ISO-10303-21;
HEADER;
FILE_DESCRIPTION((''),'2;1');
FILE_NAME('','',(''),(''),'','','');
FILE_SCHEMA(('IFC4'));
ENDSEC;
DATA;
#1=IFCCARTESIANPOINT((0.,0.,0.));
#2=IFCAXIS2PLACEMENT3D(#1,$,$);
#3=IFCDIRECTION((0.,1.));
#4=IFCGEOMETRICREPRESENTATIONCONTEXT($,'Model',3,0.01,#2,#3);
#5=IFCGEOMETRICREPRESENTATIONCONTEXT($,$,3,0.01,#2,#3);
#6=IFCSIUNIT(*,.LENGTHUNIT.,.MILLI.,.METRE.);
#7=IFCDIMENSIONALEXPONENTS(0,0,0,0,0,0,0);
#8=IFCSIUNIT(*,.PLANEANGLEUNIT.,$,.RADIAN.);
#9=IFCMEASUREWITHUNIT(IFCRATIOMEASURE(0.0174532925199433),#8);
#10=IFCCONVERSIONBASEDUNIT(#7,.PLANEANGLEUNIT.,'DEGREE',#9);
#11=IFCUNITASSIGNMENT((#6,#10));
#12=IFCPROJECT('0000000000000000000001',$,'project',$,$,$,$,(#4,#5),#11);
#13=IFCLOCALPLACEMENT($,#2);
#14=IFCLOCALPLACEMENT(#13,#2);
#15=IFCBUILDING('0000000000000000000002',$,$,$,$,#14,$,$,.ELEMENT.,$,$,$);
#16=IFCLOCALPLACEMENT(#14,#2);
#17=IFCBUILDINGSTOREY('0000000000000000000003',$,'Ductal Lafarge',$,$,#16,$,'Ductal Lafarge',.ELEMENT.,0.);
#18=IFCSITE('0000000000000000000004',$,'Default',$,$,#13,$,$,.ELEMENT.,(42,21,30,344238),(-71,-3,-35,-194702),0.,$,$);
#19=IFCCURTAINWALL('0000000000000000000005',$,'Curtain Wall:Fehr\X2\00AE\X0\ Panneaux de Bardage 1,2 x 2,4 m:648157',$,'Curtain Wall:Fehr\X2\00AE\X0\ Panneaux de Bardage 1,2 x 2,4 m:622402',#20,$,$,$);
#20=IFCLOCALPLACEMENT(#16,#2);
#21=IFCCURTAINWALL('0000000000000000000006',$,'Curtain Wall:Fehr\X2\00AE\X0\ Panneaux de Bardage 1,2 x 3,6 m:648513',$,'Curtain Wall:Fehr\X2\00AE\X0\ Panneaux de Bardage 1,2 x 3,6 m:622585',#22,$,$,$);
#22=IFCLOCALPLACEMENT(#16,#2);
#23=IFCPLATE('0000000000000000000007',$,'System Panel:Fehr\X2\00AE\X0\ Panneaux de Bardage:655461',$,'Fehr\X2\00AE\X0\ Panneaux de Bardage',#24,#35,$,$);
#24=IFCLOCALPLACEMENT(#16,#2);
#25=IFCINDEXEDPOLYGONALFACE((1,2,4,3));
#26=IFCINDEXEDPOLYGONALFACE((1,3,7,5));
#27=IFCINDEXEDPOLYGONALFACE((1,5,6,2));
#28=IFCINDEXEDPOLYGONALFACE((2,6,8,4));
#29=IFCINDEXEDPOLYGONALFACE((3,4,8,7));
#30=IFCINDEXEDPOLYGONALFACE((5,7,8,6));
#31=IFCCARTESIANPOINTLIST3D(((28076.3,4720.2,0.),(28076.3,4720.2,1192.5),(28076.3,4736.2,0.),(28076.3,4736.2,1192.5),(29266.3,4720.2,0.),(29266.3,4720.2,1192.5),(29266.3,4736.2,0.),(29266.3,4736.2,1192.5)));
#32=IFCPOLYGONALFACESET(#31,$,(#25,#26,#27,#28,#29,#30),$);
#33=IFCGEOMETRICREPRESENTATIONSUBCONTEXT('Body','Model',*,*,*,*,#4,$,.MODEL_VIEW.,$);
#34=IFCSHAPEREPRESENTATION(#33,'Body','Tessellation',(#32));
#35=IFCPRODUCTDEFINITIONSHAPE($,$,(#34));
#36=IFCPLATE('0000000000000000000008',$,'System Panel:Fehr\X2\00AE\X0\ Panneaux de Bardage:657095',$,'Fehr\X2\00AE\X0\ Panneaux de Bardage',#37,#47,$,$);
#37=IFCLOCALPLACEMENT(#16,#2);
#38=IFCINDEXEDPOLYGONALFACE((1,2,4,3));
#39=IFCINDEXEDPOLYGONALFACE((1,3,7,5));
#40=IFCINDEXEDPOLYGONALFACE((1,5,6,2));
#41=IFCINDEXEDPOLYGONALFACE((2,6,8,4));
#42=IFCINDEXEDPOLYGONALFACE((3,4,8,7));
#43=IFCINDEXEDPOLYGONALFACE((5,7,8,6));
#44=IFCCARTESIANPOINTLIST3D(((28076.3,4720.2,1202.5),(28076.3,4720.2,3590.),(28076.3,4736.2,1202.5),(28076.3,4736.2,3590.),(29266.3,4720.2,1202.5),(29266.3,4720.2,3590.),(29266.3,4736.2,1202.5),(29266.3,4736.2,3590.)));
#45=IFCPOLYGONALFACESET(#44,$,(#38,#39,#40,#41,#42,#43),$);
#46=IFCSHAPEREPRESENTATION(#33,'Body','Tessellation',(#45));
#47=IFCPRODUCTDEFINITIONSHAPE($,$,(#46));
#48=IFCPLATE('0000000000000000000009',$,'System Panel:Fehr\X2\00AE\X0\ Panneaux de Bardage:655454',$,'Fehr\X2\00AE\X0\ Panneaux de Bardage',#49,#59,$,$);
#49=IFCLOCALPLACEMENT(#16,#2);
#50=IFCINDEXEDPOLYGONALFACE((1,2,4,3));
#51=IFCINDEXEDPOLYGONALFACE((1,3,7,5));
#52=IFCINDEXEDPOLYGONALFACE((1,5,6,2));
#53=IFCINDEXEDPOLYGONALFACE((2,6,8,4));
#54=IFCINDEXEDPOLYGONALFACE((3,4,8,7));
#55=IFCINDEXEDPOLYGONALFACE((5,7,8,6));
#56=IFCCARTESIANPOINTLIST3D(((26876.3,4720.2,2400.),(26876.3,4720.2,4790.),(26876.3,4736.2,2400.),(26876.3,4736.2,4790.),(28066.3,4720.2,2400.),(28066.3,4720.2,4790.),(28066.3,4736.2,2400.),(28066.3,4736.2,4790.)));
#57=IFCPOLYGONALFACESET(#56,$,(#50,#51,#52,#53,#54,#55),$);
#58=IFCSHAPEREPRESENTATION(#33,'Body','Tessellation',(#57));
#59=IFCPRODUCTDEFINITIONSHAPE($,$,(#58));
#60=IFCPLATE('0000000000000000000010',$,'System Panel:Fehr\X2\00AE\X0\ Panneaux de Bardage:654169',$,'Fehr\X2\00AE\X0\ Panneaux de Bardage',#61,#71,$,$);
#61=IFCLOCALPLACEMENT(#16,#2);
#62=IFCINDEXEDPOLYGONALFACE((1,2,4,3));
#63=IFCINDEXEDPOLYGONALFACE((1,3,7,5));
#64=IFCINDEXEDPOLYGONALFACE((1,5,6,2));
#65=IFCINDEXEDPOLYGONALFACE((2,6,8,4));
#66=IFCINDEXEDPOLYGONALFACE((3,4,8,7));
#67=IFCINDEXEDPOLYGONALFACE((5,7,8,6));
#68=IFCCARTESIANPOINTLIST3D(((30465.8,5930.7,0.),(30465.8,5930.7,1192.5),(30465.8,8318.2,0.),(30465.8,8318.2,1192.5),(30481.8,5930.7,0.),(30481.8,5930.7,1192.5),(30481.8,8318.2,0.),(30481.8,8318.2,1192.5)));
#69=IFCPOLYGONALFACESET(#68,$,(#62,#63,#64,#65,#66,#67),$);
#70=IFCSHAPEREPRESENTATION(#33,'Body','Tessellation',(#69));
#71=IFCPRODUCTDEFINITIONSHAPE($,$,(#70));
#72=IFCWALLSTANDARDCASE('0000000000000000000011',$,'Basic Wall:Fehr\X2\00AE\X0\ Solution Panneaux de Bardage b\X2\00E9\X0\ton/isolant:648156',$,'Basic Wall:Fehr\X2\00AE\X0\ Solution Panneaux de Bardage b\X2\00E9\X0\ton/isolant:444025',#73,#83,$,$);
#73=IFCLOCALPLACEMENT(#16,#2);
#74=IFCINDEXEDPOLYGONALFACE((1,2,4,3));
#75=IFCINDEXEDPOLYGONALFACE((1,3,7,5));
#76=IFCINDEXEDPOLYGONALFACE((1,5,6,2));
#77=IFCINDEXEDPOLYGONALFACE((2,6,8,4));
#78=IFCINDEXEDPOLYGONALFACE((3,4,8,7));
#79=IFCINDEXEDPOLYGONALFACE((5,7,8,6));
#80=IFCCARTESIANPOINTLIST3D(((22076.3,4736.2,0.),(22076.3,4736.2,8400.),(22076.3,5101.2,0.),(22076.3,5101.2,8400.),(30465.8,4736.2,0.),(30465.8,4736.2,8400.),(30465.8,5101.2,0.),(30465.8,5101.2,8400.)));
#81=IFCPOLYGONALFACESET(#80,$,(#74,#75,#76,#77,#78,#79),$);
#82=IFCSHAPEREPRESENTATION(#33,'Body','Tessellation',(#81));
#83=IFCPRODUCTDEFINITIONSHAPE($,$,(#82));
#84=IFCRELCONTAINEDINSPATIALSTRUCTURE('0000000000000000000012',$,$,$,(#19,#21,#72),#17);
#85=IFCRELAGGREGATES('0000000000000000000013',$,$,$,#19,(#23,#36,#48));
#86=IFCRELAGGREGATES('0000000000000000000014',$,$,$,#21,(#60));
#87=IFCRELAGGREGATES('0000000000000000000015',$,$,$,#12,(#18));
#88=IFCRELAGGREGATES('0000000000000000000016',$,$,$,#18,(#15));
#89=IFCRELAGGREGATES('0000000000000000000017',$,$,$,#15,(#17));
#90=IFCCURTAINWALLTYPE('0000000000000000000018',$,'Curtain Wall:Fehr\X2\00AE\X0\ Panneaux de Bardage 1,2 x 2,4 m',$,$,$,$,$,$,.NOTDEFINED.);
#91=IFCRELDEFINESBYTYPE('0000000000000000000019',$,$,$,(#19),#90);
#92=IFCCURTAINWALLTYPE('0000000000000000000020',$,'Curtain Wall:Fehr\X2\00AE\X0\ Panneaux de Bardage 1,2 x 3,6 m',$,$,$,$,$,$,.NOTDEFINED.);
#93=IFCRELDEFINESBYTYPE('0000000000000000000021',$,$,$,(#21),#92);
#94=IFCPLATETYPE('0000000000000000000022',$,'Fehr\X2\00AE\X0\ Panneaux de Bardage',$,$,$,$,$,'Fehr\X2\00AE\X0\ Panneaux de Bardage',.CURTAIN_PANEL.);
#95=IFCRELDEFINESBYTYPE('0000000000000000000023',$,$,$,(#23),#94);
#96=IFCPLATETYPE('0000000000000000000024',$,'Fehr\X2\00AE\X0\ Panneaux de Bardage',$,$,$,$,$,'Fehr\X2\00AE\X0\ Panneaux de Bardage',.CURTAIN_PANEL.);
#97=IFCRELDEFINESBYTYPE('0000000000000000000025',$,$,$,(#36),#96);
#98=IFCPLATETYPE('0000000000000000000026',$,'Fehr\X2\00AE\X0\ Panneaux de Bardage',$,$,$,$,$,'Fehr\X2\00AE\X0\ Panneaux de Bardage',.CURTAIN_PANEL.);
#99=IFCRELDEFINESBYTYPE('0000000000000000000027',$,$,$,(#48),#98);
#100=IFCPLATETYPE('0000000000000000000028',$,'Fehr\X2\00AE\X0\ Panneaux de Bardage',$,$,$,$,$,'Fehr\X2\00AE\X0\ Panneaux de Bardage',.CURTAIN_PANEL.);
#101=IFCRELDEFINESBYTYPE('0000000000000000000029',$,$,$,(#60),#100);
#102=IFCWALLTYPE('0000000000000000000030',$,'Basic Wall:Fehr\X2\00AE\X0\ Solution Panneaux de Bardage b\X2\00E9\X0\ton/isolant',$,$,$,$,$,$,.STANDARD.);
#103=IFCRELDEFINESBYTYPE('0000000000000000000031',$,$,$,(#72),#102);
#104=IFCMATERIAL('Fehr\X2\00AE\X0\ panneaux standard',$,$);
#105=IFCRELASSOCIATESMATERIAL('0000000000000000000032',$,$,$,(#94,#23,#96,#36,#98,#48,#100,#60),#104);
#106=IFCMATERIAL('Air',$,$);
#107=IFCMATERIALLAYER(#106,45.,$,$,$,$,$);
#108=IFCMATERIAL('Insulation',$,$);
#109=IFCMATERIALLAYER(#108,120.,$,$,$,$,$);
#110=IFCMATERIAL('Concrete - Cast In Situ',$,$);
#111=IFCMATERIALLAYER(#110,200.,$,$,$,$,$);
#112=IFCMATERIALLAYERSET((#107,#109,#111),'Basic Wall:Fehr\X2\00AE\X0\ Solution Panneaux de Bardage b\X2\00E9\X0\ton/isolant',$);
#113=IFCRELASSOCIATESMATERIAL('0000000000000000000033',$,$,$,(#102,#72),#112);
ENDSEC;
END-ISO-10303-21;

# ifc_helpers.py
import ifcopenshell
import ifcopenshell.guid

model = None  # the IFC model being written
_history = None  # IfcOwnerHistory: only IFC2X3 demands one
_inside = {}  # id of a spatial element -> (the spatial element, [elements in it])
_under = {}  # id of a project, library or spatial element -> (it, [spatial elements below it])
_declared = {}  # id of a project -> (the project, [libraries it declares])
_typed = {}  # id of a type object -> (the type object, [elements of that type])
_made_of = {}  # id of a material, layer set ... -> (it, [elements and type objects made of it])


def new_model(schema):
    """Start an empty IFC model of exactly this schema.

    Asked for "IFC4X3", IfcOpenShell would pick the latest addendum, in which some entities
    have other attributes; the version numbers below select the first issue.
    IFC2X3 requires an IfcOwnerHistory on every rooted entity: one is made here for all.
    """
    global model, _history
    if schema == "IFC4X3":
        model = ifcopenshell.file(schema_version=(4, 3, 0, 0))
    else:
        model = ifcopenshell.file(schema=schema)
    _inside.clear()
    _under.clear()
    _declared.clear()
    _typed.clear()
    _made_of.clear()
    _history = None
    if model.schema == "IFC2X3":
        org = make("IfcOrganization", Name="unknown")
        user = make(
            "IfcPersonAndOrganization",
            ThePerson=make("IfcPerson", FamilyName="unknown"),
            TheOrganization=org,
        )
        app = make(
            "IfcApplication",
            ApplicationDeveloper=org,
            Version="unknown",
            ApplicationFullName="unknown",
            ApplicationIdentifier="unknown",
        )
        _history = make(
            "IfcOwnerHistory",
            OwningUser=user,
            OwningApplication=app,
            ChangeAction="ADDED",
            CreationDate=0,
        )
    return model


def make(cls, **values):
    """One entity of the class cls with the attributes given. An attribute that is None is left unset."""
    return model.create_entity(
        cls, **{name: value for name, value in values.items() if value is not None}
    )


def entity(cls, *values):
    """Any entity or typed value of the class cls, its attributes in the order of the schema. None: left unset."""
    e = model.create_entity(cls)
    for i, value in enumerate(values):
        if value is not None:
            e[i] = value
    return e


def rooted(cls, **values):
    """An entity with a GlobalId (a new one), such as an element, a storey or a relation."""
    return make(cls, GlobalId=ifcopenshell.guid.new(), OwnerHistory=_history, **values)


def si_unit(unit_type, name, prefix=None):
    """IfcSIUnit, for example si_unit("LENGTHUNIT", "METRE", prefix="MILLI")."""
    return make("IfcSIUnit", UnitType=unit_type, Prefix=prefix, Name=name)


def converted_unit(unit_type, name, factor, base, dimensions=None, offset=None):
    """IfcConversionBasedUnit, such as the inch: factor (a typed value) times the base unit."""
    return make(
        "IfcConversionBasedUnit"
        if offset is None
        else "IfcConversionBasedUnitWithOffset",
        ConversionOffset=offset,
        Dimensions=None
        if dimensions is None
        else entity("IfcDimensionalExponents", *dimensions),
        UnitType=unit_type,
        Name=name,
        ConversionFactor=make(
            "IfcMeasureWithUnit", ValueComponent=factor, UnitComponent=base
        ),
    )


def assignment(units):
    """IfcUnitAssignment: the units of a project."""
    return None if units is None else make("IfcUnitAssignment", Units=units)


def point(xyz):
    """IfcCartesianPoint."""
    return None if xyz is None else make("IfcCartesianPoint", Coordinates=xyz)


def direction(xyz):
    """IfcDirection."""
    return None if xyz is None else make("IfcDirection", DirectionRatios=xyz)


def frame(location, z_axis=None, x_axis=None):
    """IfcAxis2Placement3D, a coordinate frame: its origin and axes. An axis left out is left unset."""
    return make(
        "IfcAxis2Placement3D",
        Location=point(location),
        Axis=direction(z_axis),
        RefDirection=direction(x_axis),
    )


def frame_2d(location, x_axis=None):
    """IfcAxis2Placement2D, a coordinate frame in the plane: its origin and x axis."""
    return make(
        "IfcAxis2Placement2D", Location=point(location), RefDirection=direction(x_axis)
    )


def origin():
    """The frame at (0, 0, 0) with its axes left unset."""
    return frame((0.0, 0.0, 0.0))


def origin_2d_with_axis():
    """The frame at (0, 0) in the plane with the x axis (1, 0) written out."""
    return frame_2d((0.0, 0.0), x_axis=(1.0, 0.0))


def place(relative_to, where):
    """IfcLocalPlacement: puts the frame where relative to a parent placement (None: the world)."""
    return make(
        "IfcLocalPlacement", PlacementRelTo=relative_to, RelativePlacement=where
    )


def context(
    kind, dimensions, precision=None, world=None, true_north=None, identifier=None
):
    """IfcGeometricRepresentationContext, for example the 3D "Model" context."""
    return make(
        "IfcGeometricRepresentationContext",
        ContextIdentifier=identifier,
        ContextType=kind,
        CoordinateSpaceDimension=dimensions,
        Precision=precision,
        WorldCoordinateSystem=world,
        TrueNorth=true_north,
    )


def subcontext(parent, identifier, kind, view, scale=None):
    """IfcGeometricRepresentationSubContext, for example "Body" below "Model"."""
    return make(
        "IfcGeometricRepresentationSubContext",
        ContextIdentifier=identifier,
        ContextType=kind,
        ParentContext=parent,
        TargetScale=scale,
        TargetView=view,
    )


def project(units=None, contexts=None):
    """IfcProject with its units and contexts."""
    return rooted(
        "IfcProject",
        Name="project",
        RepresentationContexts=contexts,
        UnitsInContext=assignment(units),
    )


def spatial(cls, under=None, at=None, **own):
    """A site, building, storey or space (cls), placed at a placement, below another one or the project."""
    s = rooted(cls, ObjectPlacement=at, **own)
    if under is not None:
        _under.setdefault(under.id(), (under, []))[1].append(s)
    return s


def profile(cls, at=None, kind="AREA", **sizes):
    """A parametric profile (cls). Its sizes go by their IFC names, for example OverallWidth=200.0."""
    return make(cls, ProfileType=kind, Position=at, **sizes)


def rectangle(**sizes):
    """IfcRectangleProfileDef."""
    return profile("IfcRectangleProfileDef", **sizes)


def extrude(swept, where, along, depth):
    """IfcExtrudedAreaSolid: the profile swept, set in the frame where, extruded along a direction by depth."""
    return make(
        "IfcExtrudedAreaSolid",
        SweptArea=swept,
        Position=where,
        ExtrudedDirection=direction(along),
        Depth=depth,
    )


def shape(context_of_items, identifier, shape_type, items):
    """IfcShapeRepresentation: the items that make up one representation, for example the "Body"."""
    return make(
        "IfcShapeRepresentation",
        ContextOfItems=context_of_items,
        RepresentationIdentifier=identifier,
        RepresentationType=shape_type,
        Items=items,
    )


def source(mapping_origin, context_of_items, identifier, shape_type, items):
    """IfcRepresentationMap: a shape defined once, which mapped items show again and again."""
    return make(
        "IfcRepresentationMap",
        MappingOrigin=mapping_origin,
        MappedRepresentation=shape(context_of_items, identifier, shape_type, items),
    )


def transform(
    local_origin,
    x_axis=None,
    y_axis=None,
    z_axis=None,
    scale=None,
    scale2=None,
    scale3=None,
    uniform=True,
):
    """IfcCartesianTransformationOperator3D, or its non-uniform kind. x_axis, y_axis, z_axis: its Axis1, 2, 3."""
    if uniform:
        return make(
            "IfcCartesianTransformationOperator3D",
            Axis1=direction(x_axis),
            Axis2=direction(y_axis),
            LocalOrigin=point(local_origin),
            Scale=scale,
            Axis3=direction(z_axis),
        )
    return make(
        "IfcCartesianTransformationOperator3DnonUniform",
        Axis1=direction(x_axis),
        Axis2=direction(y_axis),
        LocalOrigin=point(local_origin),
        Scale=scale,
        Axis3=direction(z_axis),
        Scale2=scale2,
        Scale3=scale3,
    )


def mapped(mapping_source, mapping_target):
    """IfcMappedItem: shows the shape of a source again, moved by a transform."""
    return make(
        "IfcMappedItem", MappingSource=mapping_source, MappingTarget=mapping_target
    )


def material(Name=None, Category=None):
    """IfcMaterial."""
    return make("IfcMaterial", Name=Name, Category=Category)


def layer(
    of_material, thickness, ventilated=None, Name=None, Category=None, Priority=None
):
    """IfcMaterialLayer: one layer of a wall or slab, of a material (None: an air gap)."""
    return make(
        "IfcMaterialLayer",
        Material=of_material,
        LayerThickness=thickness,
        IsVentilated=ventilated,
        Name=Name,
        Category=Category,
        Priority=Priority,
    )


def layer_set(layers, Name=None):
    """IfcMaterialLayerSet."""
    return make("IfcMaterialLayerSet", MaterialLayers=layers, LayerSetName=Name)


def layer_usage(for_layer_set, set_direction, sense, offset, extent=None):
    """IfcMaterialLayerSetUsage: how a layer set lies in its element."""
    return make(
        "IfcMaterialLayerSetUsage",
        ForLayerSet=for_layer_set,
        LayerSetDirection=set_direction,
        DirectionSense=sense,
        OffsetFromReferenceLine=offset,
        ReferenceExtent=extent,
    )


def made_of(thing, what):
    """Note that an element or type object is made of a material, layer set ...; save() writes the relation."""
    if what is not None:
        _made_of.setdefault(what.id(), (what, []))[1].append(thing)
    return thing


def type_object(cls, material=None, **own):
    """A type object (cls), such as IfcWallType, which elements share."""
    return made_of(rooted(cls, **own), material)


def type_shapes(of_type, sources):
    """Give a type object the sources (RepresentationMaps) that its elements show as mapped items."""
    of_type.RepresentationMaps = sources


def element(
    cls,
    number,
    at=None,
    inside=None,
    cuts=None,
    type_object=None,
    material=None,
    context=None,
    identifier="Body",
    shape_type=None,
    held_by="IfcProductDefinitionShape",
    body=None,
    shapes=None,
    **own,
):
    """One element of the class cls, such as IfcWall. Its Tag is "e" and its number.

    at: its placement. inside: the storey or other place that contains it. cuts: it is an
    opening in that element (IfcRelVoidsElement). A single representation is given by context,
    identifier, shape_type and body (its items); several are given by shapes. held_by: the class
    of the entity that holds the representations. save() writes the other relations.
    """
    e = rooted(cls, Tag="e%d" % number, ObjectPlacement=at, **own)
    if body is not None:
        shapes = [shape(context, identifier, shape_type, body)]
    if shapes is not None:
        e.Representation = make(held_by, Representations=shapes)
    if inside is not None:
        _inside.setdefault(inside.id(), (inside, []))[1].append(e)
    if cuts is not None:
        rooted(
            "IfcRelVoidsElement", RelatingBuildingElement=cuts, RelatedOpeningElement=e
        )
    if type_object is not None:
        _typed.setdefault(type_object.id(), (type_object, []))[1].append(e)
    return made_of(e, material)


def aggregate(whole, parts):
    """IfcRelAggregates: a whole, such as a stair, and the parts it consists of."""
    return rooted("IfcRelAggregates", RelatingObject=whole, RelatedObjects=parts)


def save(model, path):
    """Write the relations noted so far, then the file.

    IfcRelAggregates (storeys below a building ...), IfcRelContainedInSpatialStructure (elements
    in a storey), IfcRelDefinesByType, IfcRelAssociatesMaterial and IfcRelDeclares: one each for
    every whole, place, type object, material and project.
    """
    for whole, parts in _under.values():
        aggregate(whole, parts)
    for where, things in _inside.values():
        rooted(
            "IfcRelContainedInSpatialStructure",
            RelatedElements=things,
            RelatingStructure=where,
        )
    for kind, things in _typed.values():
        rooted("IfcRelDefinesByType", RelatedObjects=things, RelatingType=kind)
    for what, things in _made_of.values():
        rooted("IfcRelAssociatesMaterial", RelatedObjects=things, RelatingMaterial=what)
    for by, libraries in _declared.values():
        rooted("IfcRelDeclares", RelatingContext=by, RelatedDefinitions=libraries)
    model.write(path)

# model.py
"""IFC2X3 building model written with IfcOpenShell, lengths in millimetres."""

from ifc_helpers import new_model, entity, si_unit, converted_unit, direction, frame, frame_2d, origin, origin_2d_with_axis, place, context, subcontext, project, spatial, rectangle, extrude, source, transform, mapped, material, layer, layer_set, layer_usage, type_object, type_shapes, element, aggregate, save


model = new_model("IFC2X3")

# Units and contexts
model_context = context("Model", 3, precision=0.01, world=origin(), true_north=direction((0.0, 1.0)))
context_of_model = context(None, 3, precision=0.01, world=origin(), true_north=direction((0.0, 1.0)))
body_context = subcontext(model_context, "Body", "Model", "MODEL_VIEW")
ifc_project = project(units=[si_unit("LENGTHUNIT", "METRE", prefix="MILLI"), converted_unit("PLANEANGLEUNIT", "DEGREE", entity("IfcRatioMeasure", 0.0174532925199433), si_unit("PLANEANGLEUNIT", "RADIAN"), dimensions=[0, 0, 0, 0, 0, 0, 0])], contexts=[model_context, context_of_model])

# Site, building, storey
site_placement = place(None, origin())
site = spatial("IfcSite", under=ifc_project, at=site_placement, Name="Default", CompositionType="ELEMENT", RefLatitude=(42, 21, 30, 344238), RefLongitude=(-71, -3, -35, -194702), RefElevation=0.0)
building_placement = place(site_placement, origin())
building = spatial("IfcBuilding", under=site, at=building_placement, CompositionType="ELEMENT")
storey_placement = place(building_placement, origin())
storey = spatial("IfcBuildingStorey", under=building, at=storey_placement, Name="Ductal Lafarge", LongName="Ductal Lafarge", CompositionType="ELEMENT", Elevation=0.0)

# Curtain walls
curtain_wall_type_1 = type_object("IfcCurtainWallType", Name="Curtain Wall:Fehr® Panneaux de Bardage 1,2 x 2,4 m", PredefinedType="NOTDEFINED")
curtain_wall_1_placement = place(storey_placement, origin())
curtain_wall_1 = element("IfcCurtainWall", 1, at=curtain_wall_1_placement, inside=storey, type_object=curtain_wall_type_1, Name="Curtain Wall:Fehr® Panneaux de Bardage 1,2 x 2,4 m:648157", ObjectType="Curtain Wall:Fehr® Panneaux de Bardage 1,2 x 2,4 m:622402")
curtain_wall_type_2 = type_object("IfcCurtainWallType", Name="Curtain Wall:Fehr® Panneaux de Bardage 1,2 x 3,6 m", PredefinedType="NOTDEFINED")
curtain_wall_2_placement = place(storey_placement, origin())
curtain_wall_2 = element("IfcCurtainWall", 2, at=curtain_wall_2_placement, inside=storey, type_object=curtain_wall_type_2, Name="Curtain Wall:Fehr® Panneaux de Bardage 1,2 x 3,6 m:648513", ObjectType="Curtain Wall:Fehr® Panneaux de Bardage 1,2 x 3,6 m:622585")

# Plates
ifc_material_1 = material(Name="Fehr® panneaux standard")
plate_type_1 = type_object("IfcPlateType", Name="Fehr® Panneaux de Bardage", ElementType="Fehr® Panneaux de Bardage", PredefinedType="CURTAIN_PANEL", material=ifc_material_1)
shared_shape_1 = source(origin(), body_context, "Body", "SweptSolid", [
    extrude(rectangle(XDim=16.0, YDim=1190.0, at=origin_2d_with_axis()), frame((0.0, 0.0, 0.0), z_axis=(0.0, 0.0, 1.0), x_axis=(0.0, 1.0, 0.0)), (0.0, 0.0, 1.0), 1192.5),
])
type_shapes(plate_type_1, [shared_shape_1])
plate_1_placement = place(curtain_wall_1_placement, frame((28671.3, 4728.2, 0.0)))
plate_1 = element("IfcPlate", 3, at=plate_1_placement, type_object=plate_type_1, material=ifc_material_1, Name="System Panel:Fehr® Panneaux de Bardage:655461", ObjectType="Fehr® Panneaux de Bardage", context=body_context, shape_type="MappedRepresentation", body=[
    mapped(shared_shape_1, transform((0.0, 0.0, 0.0), scale=1.0)),
])
plate_type_2 = type_object("IfcPlateType", Name="Fehr® Panneaux de Bardage", ElementType="Fehr® Panneaux de Bardage", PredefinedType="CURTAIN_PANEL", material=ifc_material_1)
shared_shape_2 = source(origin(), body_context, "Body", "SweptSolid", [
    extrude(rectangle(XDim=2387.5, YDim=1190.0, at=frame_2d((0.4, 0.0), x_axis=(1.0, 0.0))), frame((0.0, -8.0, 1193.3), z_axis=(0.0, 1.0, 0.0), x_axis=(0.0, 0.0, 1.0)), (0.0, 0.0, 1.0), 16.0),
])
type_shapes(plate_type_2, [shared_shape_2])
plate_2_placement = place(curtain_wall_1_placement, frame((28671.3, 4728.2, 1202.5)))
plate_2 = element("IfcPlate", 4, at=plate_2_placement, type_object=plate_type_2, material=ifc_material_1, Name="System Panel:Fehr® Panneaux de Bardage:657095", ObjectType="Fehr® Panneaux de Bardage", context=body_context, shape_type="MappedRepresentation", body=[
    mapped(shared_shape_2, transform((0.0, 0.0, 0.0), scale=1.0)),
])
plate_type_3 = type_object("IfcPlateType", Name="Fehr® Panneaux de Bardage", ElementType="Fehr® Panneaux de Bardage", PredefinedType="CURTAIN_PANEL", material=ifc_material_1)
shared_shape_3 = source(origin(), body_context, "Body", "SweptSolid", [
    extrude(rectangle(XDim=2390.0, YDim=1190.0, at=origin_2d_with_axis()), frame((0.0, -8.0, 1195.0), z_axis=(0.0, 1.0, 0.0), x_axis=(0.0, 0.0, 1.0)), (0.0, 0.0, 1.0), 16.0),
])
type_shapes(plate_type_3, [shared_shape_3])
plate_3_placement = place(curtain_wall_1_placement, frame((27471.3, 4728.2, 2400.0)))
plate_3 = element("IfcPlate", 5, at=plate_3_placement, type_object=plate_type_3, material=ifc_material_1, Name="System Panel:Fehr® Panneaux de Bardage:655454", ObjectType="Fehr® Panneaux de Bardage", context=body_context, shape_type="MappedRepresentation", body=[
    mapped(shared_shape_3, transform((0.0, 0.0, 0.0), scale=1.0)),
])
aggregate(curtain_wall_1, [plate_1, plate_2, plate_3])
plate_type_4 = type_object("IfcPlateType", Name="Fehr® Panneaux de Bardage", ElementType="Fehr® Panneaux de Bardage", PredefinedType="CURTAIN_PANEL", material=ifc_material_1)
shared_shape_4 = source(origin(), body_context, "Body", "SweptSolid", [
    extrude(rectangle(XDim=1192.5, YDim=2387.5, at=frame_2d((0.0, 0.4), x_axis=(1.0, 0.0))), frame((-0.4, -8.0, 596.2), z_axis=(0.0, 1.0, 0.0), x_axis=(0.0, 0.0, 1.0)), (0.0, 0.0, 1.0), 16.0),
])
type_shapes(plate_type_4, [shared_shape_4])
plate_4_placement = place(curtain_wall_2_placement, frame((30473.8, 7124.4, 0.0), z_axis=(0.0, 0.0, 1.0), x_axis=(0.0, 1.0, 0.0)))
plate_4 = element("IfcPlate", 6, at=plate_4_placement, type_object=plate_type_4, material=ifc_material_1, Name="System Panel:Fehr® Panneaux de Bardage:654169", ObjectType="Fehr® Panneaux de Bardage", context=body_context, shape_type="MappedRepresentation", body=[
    mapped(shared_shape_4, transform((0.0, 0.0, 0.0), scale=1.0)),
])
aggregate(curtain_wall_2, [plate_4])

# Wall
ifc_material_2 = material(Name="Air")
ifc_layer_1 = layer(ifc_material_2, 45.0)
ifc_material_3 = material(Name="Insulation")
ifc_layer_2 = layer(ifc_material_3, 120.0)
ifc_material_4 = material(Name="Concrete - Cast In Situ")
ifc_layer_3 = layer(ifc_material_4, 200.0)
ifc_layer_set = layer_set([ifc_layer_1, ifc_layer_2, ifc_layer_3], Name="Basic Wall:Fehr® Solution Panneaux de Bardage béton/isolant")
ifc_layer_usage = layer_usage(ifc_layer_set, "AXIS2", "NEGATIVE", 182.5)
wall_type = type_object("IfcWallType", Name="Basic Wall:Fehr® Solution Panneaux de Bardage béton/isolant", PredefinedType="STANDARD", material=ifc_layer_set)
wall_placement = place(storey_placement, frame((30465.8, 4918.7, 0.0), z_axis=(0.0, 0.0, 1.0), x_axis=(-1.0, 0.0, 0.0)))
element("IfcWallStandardCase", 7, at=wall_placement, inside=storey, type_object=wall_type, material=ifc_layer_usage, Name="Basic Wall:Fehr® Solution Panneaux de Bardage béton/isolant:648156", ObjectType="Basic Wall:Fehr® Solution Panneaux de Bardage béton/isolant:444025", context=body_context, shape_type="SweptSolid", body=[
    extrude(rectangle(XDim=8389.5, YDim=365.0, at=frame_2d((4194.7, 0.0), x_axis=(-1.0, 0.0))), origin(), (0.0, 0.0, 1.0), 8400.0),
])

save(model, "model.ifc")
